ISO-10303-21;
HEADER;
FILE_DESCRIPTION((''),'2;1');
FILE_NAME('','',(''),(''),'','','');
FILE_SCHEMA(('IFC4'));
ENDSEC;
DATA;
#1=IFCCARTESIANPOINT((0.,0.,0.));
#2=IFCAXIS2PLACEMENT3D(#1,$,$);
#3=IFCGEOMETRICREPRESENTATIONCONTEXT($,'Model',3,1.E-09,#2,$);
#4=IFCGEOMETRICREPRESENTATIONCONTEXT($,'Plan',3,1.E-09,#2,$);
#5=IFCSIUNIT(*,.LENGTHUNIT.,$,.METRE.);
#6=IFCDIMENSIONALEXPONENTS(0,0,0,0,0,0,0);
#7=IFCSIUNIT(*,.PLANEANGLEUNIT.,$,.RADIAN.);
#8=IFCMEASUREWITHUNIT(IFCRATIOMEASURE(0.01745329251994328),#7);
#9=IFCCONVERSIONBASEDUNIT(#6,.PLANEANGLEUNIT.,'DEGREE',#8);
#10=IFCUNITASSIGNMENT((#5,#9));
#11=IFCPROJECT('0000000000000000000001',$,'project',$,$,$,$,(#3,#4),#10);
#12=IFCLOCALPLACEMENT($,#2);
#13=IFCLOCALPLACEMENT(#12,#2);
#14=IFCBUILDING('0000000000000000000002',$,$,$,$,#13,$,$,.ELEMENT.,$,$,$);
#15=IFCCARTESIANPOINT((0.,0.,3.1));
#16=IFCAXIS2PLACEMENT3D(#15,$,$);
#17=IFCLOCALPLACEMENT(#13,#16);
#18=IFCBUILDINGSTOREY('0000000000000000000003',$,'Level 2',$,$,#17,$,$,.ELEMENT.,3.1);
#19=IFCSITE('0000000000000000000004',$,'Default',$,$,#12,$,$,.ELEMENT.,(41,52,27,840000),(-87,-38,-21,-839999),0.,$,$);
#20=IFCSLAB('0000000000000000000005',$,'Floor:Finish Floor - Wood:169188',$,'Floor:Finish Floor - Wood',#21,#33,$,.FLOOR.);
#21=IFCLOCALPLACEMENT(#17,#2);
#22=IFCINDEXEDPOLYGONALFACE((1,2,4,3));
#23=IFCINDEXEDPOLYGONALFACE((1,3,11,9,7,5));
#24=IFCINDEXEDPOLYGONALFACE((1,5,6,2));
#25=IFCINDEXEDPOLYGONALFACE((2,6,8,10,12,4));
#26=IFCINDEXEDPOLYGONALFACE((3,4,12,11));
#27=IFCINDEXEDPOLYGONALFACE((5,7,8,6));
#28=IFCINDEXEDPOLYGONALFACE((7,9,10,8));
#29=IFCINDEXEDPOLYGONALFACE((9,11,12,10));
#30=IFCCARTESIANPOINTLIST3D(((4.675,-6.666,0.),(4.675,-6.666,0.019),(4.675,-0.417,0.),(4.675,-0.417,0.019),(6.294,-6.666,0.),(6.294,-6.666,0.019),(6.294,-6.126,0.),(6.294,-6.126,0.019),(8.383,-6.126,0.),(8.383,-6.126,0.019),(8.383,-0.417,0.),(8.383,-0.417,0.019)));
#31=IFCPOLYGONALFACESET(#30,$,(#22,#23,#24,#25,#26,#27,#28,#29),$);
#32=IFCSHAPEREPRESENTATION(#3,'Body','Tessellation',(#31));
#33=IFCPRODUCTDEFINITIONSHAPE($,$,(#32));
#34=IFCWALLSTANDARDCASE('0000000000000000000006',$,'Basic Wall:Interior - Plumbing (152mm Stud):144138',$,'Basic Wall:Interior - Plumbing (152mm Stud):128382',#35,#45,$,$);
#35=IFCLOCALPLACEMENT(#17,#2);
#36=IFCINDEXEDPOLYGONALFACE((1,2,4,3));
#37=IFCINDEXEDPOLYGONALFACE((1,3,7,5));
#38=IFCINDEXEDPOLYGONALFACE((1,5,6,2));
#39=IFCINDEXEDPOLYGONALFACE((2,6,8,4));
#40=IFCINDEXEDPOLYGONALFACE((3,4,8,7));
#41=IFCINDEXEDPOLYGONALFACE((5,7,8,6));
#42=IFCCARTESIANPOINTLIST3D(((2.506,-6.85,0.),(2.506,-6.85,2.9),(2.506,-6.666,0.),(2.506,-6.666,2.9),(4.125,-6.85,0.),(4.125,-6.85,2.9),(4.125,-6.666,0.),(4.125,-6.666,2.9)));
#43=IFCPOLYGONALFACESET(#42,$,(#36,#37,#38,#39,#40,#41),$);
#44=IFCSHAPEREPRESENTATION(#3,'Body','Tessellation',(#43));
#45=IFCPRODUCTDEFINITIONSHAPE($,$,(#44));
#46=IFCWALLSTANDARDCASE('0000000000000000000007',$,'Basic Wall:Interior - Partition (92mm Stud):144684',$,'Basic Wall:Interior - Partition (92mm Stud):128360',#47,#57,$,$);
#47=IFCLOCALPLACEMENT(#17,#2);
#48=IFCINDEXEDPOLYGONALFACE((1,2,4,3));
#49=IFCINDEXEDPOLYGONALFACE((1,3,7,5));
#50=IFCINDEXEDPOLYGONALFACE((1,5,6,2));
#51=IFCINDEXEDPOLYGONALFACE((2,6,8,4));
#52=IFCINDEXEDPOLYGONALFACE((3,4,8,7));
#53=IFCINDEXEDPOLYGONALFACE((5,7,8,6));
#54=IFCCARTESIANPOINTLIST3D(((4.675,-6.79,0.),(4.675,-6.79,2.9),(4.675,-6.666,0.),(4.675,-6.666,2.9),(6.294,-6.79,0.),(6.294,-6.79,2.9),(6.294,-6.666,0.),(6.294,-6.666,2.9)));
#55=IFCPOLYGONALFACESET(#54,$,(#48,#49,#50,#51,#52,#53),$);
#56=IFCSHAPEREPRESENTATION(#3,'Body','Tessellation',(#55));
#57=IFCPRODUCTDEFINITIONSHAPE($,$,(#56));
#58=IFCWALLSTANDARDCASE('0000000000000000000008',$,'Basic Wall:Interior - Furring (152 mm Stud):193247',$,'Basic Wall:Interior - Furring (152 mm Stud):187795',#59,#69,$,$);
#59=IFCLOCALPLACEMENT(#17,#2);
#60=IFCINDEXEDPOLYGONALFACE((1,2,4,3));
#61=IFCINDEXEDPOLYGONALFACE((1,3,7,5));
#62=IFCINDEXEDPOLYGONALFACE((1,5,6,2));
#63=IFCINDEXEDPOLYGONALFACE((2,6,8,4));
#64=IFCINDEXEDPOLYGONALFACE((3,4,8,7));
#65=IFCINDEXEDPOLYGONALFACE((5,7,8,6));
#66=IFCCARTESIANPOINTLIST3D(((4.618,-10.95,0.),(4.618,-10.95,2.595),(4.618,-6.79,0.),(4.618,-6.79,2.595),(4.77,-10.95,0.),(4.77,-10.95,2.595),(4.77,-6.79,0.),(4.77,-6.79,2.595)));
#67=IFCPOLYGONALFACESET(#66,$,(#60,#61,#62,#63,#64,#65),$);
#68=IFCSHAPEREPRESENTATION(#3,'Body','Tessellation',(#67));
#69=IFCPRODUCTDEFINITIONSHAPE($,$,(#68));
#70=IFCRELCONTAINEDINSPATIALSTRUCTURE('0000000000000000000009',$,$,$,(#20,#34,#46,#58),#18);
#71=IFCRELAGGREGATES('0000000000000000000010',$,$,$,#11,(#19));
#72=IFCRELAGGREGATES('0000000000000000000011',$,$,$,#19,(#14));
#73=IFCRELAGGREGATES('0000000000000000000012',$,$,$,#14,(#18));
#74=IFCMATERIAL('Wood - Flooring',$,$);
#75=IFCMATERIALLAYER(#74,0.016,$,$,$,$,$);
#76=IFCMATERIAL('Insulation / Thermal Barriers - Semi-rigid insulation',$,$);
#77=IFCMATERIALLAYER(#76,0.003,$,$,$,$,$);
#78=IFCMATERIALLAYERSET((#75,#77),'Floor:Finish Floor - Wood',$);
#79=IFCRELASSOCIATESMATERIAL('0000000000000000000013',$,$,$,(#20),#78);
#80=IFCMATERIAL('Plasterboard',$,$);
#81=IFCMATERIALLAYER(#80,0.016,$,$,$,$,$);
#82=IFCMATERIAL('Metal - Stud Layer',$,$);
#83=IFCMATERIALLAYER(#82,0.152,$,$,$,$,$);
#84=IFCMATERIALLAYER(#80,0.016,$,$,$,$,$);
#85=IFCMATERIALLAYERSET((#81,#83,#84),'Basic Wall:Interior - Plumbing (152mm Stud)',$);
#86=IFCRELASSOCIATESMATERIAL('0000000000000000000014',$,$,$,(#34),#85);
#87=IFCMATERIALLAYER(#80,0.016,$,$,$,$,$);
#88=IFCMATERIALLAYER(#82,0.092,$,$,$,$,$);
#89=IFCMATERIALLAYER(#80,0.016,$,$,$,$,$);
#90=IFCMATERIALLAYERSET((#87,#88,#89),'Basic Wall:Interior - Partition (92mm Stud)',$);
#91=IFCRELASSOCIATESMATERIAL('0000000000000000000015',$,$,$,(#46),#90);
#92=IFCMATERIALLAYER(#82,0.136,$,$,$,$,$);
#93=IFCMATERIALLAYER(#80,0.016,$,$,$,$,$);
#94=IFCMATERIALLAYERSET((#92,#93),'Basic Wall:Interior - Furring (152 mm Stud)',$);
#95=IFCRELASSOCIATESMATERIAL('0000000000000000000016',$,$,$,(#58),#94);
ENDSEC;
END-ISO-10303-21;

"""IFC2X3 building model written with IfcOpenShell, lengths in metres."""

from ifc_helpers import new_model, entity, si_unit, converted_unit, frame, frame_2d, origin, place, context, project, spatial, polyline, rectangle, outline, extrude, material, layer, layer_set, layer_usage, element, save


model = new_model("IFC2X3")

# Units and contexts
model_context = context("Model", 3, precision=1e-09, world=origin())
plan_context = context("Plan", 3, precision=1e-09, world=origin())
ifc_project = project(units=[si_unit("LENGTHUNIT", "METRE"), converted_unit("PLANEANGLEUNIT", "DEGREE", entity("IfcRatioMeasure", 0.01745329251994328), si_unit("PLANEANGLEUNIT", "RADIAN"), dimensions=[0, 0, 0, 0, 0, 0, 0])], contexts=[model_context, plan_context])

# Site, building, storey
site_placement = place(None, origin())
site = spatial("IfcSite", under=ifc_project, at=site_placement, Name="Default", CompositionType="ELEMENT", RefLatitude=(41, 52, 27, 840000), RefLongitude=(-87, -38, -21, -839999), RefElevation=0.0)
building_placement = place(site_placement, origin())
building = spatial("IfcBuilding", under=site, at=building_placement, CompositionType="ELEMENT")
storey_placement = place(building_placement, frame((0.0, 0.0, 3.1)))
storey = spatial("IfcBuildingStorey", under=building, at=storey_placement, Name="Level 2", CompositionType="ELEMENT", Elevation=3.1)

# Slab
ifc_material_1 = material(Name="Wood - Flooring")
ifc_layer_1 = layer(ifc_material_1, 0.016)
ifc_material_2 = material(Name="Insulation / Thermal Barriers - Semi-rigid insulation")
ifc_layer_2 = layer(ifc_material_2, 0.003)
ifc_layer_set_1 = layer_set([ifc_layer_1, ifc_layer_2], Name="Floor:Finish Floor - Wood")
ifc_layer_usage_1 = layer_usage(ifc_layer_set_1, "AXIS3", "POSITIVE", 0.0)
slab_placement = place(storey_placement, frame((4.675, -6.666, 0.0)))
element("IfcSlab", 1, at=slab_placement, inside=storey, material=ifc_layer_usage_1, Name="Floor:Finish Floor - Wood:169188", ObjectType="Floor:Finish Floor - Wood", PredefinedType="FLOOR", context=model_context, shape_type="SweptSolid", body=[
    extrude(outline(polyline([(-1.854, 3.1245), (-1.854, -2.5845), (0.235, -2.5845), (0.235, -3.1245), (1.854, -3.1245), (1.854, 3.1245), (-1.854, 3.1245)])), frame((1.854, 3.1245, 0.019), z_axis=(0.0, 0.0, -1.0), x_axis=(-1.0, 0.0, 0.0)), (0.0, 0.0, 1.0), 0.019),
])

# Walls
ifc_material_3 = material(Name="Plasterboard")
ifc_layer_3 = layer(ifc_material_3, 0.016)
ifc_material_4 = material(Name="Metal - Stud Layer")
ifc_layer_4 = layer(ifc_material_4, 0.152)
ifc_layer_5 = layer(ifc_material_3, 0.016)
ifc_layer_set_2 = layer_set([ifc_layer_3, ifc_layer_4, ifc_layer_5], Name="Basic Wall:Interior - Plumbing (152mm Stud)")
ifc_layer_usage_2 = layer_usage(ifc_layer_set_2, "AXIS2", "NEGATIVE", 0.092)
wall_1_placement = place(storey_placement, frame((2.506, -6.758, 0.0)))
element("IfcWallStandardCase", 2, at=wall_1_placement, inside=storey, material=ifc_layer_usage_2, Name="Basic Wall:Interior - Plumbing (152mm Stud):144138", ObjectType="Basic Wall:Interior - Plumbing (152mm Stud):128382", context=model_context, shape_type="SweptSolid", body=[
    extrude(rectangle(XDim=1.619, YDim=0.184, at=frame_2d((0.8095, 0.0), x_axis=(-1.0, 0.0))), origin(), (0.0, 0.0, 1.0), 2.9),
])
ifc_layer_6 = layer(ifc_material_3, 0.016)
ifc_layer_7 = layer(ifc_material_4, 0.092)
ifc_layer_8 = layer(ifc_material_3, 0.016)
ifc_layer_set_3 = layer_set([ifc_layer_6, ifc_layer_7, ifc_layer_8], Name="Basic Wall:Interior - Partition (92mm Stud)")
ifc_layer_usage_3 = layer_usage(ifc_layer_set_3, "AXIS2", "NEGATIVE", 0.062)
wall_2_placement = place(storey_placement, frame((4.675, -6.728, 0.0)))
element("IfcWallStandardCase", 3, at=wall_2_placement, inside=storey, material=ifc_layer_usage_3, Name="Basic Wall:Interior - Partition (92mm Stud):144684", ObjectType="Basic Wall:Interior - Partition (92mm Stud):128360", context=model_context, shape_type="SweptSolid", body=[
    extrude(rectangle(XDim=1.619, YDim=0.124, at=frame_2d((0.8095, 0.0), x_axis=(-1.0, 0.0))), origin(), (0.0, 0.0, 1.0), 2.9),
])
ifc_layer_9 = layer(ifc_material_4, 0.136)
ifc_layer_10 = layer(ifc_material_3, 0.016)
ifc_layer_set_4 = layer_set([ifc_layer_9, ifc_layer_10], Name="Basic Wall:Interior - Furring (152 mm Stud)")
ifc_layer_usage_4 = layer_usage(ifc_layer_set_4, "AXIS2", "POSITIVE", -0.076)
wall_3_placement = place(storey_placement, frame((4.694, -6.79, 0.0), z_axis=(0.0, 0.0, 1.0), x_axis=(0.0, -1.0, 0.0)))
element("IfcWallStandardCase", 4, at=wall_3_placement, inside=storey, material=ifc_layer_usage_4, Name="Basic Wall:Interior - Furring (152 mm Stud):193247", ObjectType="Basic Wall:Interior - Furring (152 mm Stud):187795", context=model_context, shape_type="SweptSolid", body=[
    extrude(rectangle(XDim=4.16, YDim=0.152, at=frame_2d((2.08, 0.0), x_axis=(-1.0, 0.0))), origin(), (0.0, 0.0, 1.0), 2.595),
])

save(model, "model.ifc")
